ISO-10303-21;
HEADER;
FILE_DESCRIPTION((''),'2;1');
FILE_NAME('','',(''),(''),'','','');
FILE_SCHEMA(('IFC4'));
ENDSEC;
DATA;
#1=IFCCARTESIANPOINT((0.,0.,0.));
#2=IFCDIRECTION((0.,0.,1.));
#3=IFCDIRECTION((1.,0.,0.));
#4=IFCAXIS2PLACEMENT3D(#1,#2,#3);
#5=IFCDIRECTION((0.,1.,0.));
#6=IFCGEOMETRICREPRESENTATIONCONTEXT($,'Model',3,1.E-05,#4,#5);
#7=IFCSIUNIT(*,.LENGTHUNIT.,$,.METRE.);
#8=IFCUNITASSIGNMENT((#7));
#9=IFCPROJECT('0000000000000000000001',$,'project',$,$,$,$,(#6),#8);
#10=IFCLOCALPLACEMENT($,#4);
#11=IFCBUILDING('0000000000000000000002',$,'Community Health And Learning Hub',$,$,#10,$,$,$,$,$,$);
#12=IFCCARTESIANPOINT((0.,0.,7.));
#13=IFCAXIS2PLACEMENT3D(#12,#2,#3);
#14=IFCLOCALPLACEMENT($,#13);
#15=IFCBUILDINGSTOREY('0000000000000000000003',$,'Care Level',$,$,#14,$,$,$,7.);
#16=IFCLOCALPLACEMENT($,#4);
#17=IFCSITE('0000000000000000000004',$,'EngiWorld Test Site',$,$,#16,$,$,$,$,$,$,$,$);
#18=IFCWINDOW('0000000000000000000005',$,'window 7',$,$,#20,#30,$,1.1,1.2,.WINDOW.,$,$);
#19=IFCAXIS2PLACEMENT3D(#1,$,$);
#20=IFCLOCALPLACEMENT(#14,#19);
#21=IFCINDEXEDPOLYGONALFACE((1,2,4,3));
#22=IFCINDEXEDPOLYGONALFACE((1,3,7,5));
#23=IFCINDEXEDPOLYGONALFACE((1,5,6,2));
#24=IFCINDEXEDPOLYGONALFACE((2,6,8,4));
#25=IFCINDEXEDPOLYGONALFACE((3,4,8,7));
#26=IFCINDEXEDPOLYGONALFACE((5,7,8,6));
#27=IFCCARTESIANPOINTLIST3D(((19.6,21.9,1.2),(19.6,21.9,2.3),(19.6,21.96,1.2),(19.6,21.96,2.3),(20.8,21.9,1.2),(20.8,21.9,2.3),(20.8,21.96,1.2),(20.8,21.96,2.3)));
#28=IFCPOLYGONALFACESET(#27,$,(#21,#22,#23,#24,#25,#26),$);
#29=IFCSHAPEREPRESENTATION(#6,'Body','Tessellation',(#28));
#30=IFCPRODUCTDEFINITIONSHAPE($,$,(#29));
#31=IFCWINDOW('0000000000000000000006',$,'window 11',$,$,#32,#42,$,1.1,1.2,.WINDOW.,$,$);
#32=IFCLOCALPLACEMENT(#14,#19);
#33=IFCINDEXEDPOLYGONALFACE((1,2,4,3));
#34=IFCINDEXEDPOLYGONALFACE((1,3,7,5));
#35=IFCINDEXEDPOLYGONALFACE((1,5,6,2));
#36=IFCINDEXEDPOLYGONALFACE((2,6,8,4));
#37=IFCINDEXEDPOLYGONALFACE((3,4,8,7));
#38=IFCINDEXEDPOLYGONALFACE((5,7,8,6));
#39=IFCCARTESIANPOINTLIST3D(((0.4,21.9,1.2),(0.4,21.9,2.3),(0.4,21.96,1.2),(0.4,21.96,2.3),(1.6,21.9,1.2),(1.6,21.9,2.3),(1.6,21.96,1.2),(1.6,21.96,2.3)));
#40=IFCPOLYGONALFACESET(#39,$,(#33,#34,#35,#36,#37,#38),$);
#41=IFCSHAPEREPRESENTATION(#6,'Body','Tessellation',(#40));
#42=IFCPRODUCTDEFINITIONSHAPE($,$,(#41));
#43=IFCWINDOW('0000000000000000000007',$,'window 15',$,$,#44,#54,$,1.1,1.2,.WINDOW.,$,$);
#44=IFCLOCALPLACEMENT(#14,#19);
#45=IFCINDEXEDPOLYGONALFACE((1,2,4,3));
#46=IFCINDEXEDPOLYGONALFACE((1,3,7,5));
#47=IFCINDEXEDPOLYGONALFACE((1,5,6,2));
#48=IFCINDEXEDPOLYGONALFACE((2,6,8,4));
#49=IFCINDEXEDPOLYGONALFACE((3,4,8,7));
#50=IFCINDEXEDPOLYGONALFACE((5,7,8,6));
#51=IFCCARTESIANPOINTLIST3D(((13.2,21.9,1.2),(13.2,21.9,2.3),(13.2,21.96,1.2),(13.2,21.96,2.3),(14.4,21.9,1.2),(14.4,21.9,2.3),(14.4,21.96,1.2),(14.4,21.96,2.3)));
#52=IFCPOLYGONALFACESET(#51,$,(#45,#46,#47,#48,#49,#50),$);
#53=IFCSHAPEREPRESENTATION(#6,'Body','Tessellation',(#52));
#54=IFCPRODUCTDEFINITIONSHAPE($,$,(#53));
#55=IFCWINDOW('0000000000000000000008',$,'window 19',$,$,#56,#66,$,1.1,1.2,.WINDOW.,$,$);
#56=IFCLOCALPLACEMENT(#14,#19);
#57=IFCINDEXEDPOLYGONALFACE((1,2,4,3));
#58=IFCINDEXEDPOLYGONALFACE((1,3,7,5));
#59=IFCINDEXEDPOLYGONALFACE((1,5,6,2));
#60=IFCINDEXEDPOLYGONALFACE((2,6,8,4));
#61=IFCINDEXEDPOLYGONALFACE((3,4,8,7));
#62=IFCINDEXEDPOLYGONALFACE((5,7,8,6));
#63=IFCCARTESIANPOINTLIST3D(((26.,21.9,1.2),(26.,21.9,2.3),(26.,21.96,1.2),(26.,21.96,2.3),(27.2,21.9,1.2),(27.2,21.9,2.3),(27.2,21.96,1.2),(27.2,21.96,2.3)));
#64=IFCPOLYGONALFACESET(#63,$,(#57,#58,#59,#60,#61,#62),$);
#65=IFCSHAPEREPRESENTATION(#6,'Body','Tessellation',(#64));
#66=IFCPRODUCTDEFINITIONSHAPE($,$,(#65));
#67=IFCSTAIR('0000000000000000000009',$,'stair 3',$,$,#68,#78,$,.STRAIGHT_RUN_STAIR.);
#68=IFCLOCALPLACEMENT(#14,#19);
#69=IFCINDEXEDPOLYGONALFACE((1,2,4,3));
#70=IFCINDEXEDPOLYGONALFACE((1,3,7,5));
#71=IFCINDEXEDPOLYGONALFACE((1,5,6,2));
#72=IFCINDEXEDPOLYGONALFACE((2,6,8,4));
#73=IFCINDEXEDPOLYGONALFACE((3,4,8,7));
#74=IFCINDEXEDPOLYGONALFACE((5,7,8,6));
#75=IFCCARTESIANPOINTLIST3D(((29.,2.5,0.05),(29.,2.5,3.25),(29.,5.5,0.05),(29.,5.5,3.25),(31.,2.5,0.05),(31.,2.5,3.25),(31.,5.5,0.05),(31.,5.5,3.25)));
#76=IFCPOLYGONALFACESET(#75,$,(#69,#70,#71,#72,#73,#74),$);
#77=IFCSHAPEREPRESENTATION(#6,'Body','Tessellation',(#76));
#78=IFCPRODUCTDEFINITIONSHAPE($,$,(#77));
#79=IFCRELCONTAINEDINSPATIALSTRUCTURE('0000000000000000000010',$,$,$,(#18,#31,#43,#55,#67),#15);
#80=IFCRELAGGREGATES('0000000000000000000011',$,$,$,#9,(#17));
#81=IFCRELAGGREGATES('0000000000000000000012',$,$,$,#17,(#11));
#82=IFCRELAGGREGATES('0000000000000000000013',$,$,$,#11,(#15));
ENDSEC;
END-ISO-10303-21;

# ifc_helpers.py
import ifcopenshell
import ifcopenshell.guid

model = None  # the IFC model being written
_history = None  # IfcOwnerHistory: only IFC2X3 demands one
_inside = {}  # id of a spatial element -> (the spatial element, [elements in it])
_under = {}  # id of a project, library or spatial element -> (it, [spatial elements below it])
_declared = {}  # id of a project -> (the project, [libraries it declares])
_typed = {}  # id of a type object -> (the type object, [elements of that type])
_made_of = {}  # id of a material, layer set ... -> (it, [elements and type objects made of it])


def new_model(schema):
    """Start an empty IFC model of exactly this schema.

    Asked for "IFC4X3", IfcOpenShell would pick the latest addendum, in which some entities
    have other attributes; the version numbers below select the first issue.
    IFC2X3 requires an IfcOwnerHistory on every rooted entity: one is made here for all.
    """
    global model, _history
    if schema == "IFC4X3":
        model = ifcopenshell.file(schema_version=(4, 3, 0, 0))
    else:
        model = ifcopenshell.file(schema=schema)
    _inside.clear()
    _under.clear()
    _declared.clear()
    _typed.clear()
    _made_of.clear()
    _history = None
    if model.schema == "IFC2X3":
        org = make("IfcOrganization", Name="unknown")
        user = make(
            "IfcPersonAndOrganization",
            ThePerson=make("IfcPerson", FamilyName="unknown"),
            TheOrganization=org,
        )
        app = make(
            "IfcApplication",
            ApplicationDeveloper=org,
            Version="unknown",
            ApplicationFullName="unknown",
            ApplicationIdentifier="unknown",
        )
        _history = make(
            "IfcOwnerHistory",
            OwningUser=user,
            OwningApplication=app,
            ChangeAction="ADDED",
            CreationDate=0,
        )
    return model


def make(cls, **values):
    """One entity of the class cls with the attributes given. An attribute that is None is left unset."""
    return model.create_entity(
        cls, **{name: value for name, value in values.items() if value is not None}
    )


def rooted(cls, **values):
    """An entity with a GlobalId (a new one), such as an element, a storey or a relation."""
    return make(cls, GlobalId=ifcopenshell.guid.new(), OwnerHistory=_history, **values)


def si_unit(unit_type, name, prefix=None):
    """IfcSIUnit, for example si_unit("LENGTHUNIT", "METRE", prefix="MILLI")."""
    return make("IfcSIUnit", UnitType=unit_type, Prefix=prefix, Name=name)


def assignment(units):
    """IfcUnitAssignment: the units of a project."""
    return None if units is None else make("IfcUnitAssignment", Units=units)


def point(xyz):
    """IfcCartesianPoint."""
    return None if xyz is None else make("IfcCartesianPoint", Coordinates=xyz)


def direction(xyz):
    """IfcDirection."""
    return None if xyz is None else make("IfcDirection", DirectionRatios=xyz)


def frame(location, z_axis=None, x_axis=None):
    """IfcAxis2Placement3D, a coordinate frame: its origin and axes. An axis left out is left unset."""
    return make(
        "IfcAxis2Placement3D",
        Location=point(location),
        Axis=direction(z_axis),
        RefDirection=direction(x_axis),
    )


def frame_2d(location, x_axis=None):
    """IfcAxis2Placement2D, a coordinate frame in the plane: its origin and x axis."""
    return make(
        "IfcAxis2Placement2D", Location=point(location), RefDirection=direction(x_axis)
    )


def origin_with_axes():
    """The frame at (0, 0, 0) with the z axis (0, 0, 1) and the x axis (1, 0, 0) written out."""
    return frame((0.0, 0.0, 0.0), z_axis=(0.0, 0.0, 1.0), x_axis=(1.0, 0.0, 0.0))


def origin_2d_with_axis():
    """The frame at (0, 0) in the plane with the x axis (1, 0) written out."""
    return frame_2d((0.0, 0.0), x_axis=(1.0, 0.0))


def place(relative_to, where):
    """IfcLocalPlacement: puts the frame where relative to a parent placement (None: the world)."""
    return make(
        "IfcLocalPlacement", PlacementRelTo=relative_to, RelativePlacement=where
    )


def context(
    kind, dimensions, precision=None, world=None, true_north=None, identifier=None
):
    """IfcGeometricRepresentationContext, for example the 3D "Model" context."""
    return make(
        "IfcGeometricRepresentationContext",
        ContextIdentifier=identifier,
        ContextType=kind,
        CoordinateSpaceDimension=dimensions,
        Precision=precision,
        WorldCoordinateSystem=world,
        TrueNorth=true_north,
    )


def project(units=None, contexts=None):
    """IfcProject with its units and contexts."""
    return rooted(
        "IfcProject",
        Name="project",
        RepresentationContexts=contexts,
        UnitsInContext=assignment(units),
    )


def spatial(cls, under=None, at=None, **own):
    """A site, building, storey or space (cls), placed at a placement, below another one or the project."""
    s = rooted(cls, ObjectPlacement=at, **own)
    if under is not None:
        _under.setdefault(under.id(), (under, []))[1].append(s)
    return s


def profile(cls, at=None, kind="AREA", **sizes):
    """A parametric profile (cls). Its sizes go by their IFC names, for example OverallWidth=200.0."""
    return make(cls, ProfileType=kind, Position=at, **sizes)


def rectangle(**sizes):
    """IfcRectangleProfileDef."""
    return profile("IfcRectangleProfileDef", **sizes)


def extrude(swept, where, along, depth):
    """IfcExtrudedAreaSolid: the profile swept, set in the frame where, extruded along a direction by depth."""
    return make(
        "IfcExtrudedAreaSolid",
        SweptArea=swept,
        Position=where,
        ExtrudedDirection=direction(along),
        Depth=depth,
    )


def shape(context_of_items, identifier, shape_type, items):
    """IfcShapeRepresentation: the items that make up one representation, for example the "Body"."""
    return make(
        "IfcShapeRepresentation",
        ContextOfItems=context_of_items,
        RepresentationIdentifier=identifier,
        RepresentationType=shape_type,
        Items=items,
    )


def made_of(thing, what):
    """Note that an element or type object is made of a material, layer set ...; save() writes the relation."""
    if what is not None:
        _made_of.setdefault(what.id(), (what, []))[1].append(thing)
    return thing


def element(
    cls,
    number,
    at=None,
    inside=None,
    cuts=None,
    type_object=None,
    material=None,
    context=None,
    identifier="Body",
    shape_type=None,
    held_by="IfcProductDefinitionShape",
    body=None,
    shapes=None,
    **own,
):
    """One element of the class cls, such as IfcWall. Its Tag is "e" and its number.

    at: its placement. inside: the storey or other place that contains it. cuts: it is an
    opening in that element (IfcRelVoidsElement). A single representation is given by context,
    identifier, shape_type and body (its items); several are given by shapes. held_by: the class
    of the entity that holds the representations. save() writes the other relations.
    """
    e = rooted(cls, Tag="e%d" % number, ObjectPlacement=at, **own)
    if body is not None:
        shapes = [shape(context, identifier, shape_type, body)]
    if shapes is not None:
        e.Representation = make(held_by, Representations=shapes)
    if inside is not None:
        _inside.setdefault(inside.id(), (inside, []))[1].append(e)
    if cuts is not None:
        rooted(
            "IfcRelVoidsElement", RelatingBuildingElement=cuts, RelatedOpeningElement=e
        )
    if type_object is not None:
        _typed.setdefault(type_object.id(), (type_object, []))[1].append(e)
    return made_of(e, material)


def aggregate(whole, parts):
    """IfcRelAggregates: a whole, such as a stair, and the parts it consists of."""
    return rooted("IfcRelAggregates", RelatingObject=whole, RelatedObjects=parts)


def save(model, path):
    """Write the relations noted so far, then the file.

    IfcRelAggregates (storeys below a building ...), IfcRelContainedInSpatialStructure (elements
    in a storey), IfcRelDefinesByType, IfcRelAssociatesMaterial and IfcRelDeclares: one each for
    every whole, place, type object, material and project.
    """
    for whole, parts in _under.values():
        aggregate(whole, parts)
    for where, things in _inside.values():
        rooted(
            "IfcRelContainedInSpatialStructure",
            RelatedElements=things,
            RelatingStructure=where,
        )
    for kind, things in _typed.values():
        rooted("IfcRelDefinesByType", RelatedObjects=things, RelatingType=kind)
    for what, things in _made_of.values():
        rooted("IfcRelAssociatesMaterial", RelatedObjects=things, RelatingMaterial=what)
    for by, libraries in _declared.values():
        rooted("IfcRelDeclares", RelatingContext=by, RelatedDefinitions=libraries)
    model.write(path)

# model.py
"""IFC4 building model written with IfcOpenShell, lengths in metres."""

from ifc_helpers import new_model, si_unit, direction, frame, origin_with_axes, origin_2d_with_axis, place, context, project, spatial, rectangle, extrude, element, save


model = new_model("IFC4")

# Units and contexts
model_context = context("Model", 3, precision=1e-05, world=origin_with_axes(), true_north=direction((0.0, 1.0, 0.0)))
ifc_project = project(units=[si_unit("LENGTHUNIT", "METRE")], contexts=[model_context])

# Site, building, storey
site_placement = place(None, origin_with_axes())
site = spatial("IfcSite", under=ifc_project, at=site_placement, Name="EngiWorld Test Site")
building_placement = place(None, origin_with_axes())
building = spatial("IfcBuilding", under=site, at=building_placement, Name="Community Health And Learning Hub")
storey_placement = place(None, frame((0.0, 0.0, 7.0), z_axis=(0.0, 0.0, 1.0), x_axis=(1.0, 0.0, 0.0)))
storey = spatial("IfcBuildingStorey", under=building, at=storey_placement, Name="Care Level", Elevation=7.0)

# Windows
for number, where, z_axis, x_axis, name in (
    (1, (20.2, 21.93, 8.2), (0.0, 0.0, 1.0), (1.0, 0.0, 0.0), "window 7"),
    (2, (1.0, 21.93, 8.2), (0.0, 0.0, 1.0), (1.0, 0.0, 0.0), "window 11"),
    (3, (13.8, 21.93, 8.2), (0.0, 0.0, 1.0), (1.0, 0.0, 0.0), "window 15"),
    (4, (26.6, 21.93, 8.2), (0.0, 0.0, 1.0), (1.0, 0.0, 0.0), "window 19"),
):
    element("IfcWindow", number, at=place(None, frame(where, z_axis=z_axis, x_axis=x_axis)), inside=storey, Name=name, OverallHeight=1.1, OverallWidth=1.2, PredefinedType="WINDOW", context=model_context, shape_type="SweptSolid", body=[
        extrude(rectangle(XDim=1.2, YDim=0.06, at=origin_2d_with_axis()), origin_with_axes(), (0.0, 0.0, 1.0), 1.1),
    ])

# Stair
stair_placement = place(None, frame((30.0, 4.0, 7.05), z_axis=(0.0, 0.0, 1.0), x_axis=(1.0, 0.0, 0.0)))
element("IfcStair", 5, at=stair_placement, inside=storey, Name="stair 3", PredefinedType="STRAIGHT_RUN_STAIR", context=model_context, shape_type="SweptSolid", body=[
    extrude(rectangle(XDim=2.0, YDim=3.0, at=origin_2d_with_axis()), origin_with_axes(), (0.0, 0.0, 1.0), 3.2),
])

save(model, "model.ifc")
